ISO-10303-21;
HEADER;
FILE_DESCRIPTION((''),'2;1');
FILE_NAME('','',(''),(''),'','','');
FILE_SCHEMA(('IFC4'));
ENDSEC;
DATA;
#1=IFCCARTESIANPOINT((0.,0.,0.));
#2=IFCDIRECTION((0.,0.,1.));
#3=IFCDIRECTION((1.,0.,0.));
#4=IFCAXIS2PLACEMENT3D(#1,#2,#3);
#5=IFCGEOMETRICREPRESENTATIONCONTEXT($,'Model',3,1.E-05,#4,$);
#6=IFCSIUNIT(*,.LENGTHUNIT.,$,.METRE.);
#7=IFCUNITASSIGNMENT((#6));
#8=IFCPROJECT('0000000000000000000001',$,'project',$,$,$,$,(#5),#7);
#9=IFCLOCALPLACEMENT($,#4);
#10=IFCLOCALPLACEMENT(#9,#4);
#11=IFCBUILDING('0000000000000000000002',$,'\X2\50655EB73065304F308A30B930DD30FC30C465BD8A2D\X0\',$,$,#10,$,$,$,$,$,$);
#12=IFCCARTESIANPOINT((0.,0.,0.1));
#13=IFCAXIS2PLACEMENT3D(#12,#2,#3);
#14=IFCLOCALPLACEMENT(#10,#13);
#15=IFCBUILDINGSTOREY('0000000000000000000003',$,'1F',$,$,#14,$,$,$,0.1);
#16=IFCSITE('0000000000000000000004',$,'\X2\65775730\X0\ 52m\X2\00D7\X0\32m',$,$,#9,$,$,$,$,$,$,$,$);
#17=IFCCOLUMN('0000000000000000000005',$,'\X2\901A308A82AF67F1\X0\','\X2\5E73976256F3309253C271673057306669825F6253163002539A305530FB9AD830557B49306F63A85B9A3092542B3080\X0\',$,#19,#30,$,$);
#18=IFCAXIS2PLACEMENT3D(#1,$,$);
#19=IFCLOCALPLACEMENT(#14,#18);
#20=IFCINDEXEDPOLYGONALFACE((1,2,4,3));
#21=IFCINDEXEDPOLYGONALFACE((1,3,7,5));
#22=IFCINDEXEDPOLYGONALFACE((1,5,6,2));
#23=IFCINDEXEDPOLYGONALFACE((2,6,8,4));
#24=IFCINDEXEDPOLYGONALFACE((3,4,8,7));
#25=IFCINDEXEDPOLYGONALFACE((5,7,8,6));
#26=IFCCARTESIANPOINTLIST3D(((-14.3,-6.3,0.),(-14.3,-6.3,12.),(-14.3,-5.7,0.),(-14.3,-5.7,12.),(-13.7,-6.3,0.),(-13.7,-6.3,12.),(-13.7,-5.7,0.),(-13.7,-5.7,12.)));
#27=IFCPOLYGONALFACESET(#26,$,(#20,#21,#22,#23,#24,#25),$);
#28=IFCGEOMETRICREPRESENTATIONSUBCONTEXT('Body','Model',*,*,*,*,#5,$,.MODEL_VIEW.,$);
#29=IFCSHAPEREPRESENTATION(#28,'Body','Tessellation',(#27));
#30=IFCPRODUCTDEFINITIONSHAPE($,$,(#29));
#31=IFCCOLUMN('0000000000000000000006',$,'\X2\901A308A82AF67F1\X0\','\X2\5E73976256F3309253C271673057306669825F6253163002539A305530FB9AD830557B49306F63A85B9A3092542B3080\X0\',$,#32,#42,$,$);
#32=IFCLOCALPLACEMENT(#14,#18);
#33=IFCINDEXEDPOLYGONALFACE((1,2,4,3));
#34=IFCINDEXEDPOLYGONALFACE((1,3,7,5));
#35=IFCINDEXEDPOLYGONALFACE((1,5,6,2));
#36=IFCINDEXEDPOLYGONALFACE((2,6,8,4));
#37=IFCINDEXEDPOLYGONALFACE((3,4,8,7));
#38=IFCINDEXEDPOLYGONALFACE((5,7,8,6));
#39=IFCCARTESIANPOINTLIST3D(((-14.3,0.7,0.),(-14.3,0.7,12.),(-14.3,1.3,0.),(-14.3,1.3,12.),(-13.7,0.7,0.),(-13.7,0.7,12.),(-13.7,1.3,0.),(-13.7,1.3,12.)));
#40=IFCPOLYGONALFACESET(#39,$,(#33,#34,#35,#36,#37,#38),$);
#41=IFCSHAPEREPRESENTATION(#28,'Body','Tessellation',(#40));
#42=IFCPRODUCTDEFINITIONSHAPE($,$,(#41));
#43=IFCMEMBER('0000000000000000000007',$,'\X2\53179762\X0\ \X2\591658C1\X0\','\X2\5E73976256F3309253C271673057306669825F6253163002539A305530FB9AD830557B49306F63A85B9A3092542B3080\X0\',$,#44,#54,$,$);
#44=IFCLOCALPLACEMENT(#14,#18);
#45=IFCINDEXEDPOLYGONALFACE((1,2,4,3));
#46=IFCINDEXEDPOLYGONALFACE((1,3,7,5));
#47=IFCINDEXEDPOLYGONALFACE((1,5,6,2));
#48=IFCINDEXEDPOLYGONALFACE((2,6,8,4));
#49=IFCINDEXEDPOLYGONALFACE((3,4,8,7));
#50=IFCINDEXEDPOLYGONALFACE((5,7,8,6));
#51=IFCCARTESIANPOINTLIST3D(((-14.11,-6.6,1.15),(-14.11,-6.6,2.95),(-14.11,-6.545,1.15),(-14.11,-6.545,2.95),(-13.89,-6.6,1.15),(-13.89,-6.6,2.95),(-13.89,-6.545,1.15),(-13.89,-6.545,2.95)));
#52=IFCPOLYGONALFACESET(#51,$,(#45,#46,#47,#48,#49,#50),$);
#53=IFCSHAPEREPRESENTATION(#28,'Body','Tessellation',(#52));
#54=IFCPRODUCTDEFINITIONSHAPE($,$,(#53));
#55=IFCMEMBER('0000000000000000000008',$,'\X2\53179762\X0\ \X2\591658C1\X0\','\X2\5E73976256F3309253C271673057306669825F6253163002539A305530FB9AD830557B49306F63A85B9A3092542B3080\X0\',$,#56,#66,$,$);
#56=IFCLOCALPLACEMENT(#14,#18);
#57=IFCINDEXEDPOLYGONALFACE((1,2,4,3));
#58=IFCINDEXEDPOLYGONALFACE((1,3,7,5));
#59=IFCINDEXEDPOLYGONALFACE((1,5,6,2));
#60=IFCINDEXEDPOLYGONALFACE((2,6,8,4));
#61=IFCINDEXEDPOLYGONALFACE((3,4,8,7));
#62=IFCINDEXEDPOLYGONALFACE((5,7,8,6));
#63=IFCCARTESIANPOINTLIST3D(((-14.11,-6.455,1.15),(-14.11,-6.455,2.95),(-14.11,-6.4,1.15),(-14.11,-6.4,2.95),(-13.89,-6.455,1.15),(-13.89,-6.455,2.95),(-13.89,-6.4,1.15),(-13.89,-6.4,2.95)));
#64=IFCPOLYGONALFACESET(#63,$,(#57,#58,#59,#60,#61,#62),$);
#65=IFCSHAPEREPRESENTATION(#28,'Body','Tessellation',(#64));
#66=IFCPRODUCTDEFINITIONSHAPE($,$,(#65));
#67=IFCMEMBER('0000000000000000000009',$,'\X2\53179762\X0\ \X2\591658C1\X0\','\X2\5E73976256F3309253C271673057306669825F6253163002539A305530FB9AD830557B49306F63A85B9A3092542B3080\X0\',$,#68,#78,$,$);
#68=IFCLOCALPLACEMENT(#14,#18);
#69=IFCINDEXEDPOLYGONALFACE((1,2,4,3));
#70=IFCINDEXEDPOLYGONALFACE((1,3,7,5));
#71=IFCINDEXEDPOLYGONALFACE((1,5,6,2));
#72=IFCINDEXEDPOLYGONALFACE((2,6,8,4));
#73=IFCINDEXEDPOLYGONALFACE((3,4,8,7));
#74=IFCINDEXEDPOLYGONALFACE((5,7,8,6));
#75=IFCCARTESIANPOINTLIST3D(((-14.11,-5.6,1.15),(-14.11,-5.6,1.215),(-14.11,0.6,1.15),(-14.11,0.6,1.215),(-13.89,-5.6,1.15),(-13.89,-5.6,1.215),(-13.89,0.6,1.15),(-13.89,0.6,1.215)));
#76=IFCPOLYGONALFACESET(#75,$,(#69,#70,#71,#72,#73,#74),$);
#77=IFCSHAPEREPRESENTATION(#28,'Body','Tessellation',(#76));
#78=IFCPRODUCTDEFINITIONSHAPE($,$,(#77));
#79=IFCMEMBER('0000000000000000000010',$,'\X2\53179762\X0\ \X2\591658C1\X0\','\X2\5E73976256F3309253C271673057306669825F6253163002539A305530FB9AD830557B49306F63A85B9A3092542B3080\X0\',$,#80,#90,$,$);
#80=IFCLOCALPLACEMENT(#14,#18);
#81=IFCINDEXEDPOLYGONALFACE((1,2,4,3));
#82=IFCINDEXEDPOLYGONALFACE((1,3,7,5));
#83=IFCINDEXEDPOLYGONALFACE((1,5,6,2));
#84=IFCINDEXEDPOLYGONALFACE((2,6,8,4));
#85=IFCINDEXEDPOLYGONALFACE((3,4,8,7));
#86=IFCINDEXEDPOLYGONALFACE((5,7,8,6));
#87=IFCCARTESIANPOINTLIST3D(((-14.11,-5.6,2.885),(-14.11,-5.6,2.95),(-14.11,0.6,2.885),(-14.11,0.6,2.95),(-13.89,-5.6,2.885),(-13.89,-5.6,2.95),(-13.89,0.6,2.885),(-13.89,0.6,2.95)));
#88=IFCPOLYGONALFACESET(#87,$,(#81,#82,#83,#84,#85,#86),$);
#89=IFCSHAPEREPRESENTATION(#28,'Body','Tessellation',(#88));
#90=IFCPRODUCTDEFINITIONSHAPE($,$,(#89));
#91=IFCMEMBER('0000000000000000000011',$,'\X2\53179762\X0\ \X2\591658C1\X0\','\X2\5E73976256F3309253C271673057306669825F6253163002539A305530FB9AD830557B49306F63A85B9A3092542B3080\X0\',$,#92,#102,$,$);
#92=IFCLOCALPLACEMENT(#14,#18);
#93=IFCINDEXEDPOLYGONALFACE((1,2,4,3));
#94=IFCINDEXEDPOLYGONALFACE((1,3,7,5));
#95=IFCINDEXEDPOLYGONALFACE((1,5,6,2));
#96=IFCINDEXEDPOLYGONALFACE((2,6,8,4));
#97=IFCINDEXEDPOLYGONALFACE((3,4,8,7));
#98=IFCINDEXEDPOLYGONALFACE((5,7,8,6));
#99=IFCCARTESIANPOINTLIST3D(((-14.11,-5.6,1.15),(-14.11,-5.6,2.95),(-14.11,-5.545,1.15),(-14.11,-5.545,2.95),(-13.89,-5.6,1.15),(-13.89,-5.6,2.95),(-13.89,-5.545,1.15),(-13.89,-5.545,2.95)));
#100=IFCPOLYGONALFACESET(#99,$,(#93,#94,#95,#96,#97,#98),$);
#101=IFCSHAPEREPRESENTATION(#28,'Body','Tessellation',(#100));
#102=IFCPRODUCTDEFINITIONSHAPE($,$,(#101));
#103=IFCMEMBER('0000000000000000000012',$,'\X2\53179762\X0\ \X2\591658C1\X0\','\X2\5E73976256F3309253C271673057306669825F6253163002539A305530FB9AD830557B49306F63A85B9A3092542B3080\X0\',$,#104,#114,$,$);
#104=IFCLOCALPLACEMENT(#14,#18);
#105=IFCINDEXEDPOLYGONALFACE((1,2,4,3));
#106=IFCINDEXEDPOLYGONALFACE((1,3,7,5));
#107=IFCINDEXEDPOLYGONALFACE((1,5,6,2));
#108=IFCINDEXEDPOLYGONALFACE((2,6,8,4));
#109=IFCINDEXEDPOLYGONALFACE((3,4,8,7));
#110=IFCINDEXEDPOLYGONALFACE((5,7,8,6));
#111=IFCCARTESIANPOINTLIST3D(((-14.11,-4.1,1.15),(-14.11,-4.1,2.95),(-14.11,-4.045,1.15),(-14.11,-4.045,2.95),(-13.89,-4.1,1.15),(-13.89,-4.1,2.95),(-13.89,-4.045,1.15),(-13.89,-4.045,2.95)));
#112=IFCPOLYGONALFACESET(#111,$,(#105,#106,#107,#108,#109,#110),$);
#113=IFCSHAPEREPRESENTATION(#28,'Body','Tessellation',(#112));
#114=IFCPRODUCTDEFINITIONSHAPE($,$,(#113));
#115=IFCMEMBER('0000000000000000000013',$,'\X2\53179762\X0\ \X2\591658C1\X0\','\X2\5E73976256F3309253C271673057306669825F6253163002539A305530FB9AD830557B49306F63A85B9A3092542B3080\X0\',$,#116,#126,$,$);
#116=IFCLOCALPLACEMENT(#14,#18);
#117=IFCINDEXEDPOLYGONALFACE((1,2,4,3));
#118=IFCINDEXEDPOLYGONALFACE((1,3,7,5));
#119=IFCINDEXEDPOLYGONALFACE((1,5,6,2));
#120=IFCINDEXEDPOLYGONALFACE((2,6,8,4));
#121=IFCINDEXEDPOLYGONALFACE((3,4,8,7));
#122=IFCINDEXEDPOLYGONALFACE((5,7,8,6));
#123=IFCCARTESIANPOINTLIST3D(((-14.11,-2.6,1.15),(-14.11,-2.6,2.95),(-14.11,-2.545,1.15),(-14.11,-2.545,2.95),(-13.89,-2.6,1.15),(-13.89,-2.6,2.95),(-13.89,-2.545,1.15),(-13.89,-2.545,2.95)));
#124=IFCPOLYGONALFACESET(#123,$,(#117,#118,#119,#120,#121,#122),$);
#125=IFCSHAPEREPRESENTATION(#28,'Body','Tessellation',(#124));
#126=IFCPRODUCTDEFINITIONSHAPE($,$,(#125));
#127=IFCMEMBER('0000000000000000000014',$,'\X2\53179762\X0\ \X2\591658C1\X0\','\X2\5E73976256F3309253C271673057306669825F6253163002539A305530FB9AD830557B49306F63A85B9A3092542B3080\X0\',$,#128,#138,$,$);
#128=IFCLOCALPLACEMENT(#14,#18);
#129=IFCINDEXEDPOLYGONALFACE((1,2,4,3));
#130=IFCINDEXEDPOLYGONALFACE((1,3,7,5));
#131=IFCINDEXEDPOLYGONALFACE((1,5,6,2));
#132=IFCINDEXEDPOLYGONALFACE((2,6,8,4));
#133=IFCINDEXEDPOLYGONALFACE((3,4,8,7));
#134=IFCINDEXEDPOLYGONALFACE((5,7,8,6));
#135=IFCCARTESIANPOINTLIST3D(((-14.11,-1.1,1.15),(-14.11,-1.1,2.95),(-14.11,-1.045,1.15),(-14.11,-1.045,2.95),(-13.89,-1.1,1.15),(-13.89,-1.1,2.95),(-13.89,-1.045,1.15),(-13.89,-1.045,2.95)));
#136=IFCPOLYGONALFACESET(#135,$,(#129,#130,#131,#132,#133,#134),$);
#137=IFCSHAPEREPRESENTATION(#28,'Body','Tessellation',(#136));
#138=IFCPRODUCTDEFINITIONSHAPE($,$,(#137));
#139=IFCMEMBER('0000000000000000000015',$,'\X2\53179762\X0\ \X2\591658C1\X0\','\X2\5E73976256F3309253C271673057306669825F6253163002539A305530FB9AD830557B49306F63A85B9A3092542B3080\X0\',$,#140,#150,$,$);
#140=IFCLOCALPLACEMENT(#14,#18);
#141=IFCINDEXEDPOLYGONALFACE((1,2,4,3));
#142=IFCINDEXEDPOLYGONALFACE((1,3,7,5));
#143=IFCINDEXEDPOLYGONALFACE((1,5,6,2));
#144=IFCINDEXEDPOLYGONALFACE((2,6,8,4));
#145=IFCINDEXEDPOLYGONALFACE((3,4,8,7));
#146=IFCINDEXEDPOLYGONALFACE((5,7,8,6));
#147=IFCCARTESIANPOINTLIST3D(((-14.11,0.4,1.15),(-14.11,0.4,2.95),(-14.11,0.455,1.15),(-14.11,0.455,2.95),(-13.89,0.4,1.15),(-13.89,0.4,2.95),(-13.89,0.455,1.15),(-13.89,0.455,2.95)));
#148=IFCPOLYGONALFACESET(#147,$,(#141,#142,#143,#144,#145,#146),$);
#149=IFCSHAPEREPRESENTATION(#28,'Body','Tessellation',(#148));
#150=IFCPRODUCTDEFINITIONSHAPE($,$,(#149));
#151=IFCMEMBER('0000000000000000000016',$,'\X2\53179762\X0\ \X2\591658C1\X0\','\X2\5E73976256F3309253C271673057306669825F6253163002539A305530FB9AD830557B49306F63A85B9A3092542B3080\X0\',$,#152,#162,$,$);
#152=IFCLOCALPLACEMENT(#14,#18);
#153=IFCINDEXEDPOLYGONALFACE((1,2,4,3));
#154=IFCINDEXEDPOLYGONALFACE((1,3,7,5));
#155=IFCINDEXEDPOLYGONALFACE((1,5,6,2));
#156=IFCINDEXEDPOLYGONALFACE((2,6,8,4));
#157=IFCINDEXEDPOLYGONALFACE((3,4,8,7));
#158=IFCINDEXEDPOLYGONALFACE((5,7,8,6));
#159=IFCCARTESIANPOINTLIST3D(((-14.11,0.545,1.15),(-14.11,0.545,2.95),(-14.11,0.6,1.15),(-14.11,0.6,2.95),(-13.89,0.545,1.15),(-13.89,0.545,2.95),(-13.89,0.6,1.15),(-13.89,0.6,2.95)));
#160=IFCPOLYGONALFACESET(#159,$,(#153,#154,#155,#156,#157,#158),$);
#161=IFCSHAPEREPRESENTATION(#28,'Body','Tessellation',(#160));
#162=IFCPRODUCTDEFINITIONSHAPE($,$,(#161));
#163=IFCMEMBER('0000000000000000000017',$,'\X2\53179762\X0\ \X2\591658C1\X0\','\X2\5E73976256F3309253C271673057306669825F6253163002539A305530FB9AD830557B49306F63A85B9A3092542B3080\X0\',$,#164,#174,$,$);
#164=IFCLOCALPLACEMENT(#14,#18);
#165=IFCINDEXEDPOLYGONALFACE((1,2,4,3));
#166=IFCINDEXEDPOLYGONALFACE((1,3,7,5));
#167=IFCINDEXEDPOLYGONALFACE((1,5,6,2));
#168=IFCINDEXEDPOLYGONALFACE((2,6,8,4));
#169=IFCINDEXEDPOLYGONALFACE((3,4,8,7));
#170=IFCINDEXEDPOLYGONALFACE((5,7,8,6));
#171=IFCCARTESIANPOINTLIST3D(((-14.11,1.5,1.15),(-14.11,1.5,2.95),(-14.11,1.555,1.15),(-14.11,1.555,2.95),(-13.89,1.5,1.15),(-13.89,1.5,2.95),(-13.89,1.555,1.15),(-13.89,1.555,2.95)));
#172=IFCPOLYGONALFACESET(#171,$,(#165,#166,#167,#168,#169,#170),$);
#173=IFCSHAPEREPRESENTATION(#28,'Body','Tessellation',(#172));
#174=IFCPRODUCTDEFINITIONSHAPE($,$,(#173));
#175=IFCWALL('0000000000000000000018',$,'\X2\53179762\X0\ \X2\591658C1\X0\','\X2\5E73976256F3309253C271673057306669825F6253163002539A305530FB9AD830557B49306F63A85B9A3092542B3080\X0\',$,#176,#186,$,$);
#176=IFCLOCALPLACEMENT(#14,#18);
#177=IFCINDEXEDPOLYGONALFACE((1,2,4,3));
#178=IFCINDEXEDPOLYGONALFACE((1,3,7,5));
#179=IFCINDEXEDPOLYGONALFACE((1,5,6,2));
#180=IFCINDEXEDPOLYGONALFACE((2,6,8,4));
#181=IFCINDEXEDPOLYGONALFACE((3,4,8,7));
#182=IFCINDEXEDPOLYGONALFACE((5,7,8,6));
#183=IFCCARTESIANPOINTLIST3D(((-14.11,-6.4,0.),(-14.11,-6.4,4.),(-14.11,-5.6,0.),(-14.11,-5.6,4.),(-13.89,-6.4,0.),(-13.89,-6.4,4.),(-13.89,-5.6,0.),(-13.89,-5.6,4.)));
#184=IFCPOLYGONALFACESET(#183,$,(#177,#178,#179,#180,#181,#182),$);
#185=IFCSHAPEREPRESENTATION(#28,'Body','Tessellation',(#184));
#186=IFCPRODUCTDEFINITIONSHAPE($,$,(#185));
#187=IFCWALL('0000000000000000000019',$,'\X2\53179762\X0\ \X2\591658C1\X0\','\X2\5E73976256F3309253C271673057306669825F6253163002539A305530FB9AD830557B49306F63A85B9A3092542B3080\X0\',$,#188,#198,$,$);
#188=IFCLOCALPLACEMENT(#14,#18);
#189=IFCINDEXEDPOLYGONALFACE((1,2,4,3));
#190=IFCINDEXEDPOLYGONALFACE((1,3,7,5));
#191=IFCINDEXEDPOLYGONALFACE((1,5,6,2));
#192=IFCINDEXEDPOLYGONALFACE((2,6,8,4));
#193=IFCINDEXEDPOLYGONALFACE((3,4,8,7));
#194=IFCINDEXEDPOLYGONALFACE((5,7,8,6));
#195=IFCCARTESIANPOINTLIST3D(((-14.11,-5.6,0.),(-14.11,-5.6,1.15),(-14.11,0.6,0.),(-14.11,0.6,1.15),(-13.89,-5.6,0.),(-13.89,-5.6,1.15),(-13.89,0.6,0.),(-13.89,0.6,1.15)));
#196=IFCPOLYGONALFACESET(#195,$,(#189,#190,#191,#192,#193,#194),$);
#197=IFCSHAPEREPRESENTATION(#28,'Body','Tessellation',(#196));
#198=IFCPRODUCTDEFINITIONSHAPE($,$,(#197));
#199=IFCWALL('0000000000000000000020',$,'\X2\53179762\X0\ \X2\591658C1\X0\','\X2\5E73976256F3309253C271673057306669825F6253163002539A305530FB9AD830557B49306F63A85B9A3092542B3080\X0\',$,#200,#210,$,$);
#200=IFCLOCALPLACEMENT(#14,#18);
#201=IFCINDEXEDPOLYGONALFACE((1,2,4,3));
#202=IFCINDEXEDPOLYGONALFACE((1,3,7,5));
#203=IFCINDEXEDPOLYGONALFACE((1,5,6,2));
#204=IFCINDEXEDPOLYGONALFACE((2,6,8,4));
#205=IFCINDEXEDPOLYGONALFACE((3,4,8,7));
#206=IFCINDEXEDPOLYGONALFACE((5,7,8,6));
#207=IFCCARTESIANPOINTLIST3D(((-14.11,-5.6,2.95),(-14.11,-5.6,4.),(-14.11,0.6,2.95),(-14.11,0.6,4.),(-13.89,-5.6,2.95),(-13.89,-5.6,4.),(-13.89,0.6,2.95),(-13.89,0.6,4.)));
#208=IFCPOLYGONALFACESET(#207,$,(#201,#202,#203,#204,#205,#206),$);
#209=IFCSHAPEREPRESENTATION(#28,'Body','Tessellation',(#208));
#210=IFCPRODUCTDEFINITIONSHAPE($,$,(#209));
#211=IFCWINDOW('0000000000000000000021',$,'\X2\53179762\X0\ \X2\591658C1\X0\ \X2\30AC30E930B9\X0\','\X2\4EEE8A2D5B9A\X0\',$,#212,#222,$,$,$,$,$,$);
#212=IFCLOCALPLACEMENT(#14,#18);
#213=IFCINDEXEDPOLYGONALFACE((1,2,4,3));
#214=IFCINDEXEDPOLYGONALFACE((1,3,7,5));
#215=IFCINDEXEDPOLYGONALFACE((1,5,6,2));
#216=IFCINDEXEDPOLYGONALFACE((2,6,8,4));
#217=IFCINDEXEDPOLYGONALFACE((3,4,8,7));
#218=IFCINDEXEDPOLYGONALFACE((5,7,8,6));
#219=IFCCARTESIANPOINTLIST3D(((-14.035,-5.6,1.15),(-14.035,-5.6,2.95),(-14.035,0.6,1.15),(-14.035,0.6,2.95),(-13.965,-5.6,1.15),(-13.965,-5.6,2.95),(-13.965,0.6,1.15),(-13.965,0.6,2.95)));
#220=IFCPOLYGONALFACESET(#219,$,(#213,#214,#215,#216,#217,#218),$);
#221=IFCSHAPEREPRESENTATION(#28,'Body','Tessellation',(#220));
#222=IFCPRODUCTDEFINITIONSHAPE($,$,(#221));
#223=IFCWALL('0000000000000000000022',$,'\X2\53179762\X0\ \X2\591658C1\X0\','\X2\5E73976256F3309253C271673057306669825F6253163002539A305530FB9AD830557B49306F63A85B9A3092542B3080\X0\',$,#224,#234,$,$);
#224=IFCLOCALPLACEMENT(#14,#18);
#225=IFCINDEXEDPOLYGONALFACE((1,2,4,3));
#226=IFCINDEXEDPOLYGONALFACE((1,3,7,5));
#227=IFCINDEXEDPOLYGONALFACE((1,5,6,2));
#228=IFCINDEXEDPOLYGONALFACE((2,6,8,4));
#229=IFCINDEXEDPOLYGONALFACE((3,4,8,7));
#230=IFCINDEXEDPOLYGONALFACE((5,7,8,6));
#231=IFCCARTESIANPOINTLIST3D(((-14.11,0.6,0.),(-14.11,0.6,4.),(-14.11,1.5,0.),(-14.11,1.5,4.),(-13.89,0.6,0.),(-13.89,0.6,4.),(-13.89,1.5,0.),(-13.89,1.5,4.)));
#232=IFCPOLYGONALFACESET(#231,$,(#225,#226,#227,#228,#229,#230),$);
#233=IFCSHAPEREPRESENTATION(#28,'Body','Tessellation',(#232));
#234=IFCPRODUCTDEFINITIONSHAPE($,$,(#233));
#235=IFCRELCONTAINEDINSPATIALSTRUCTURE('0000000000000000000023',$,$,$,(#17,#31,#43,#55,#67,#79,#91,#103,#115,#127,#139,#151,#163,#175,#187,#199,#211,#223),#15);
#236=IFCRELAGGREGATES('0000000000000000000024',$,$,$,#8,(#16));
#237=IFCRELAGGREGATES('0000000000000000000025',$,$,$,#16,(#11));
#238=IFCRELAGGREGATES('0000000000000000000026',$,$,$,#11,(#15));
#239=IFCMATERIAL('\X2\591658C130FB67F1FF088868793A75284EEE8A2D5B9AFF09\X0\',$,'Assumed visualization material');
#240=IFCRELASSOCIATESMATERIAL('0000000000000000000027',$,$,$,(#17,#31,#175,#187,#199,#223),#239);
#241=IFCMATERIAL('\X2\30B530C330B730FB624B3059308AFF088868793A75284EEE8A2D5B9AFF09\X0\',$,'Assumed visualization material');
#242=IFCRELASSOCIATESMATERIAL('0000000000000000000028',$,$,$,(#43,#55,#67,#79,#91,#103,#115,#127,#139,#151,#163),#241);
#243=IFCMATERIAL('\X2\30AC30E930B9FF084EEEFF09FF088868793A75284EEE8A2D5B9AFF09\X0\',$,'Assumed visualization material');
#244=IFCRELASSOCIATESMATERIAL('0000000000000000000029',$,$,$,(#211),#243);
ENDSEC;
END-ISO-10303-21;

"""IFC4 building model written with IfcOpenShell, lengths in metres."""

from ifc_helpers import new_model, si_unit, frame, origin_with_axes, place, context, subcontext, project, spatial, rectangle, extrude, material, element, save


model = new_model("IFC4")

# Units and contexts
model_context = context("Model", 3, precision=1e-05, world=origin_with_axes())
body_context = subcontext(model_context, "Body", "Model", "MODEL_VIEW")
ifc_project = project(units=[si_unit("LENGTHUNIT", "METRE")], contexts=[model_context])

# Site, building, storey
site_placement = place(None, origin_with_axes())
site = spatial("IfcSite", under=ifc_project, at=site_placement, Name="敷地 52m×32m")
building_placement = place(site_placement, origin_with_axes())
building = spatial("IfcBuilding", under=site, at=building_placement, Name="健康づくりスポーツ施設")
storey_placement = place(building_placement, frame((0.0, 0.0, 0.1), z_axis=(0.0, 0.0, 1.0), x_axis=(1.0, 0.0, 0.0)))
storey = spatial("IfcBuildingStorey", under=building, at=storey_placement, Name="1F", Elevation=0.1)

# Columns
ifc_material_1 = material(Name="外壁・柱（表示用仮設定）", Category="Assumed visualization material")
for number, where, z_axis, x_axis, name in (
    (1, (-14.0, -6.0, 0.0), (0.0, 0.0, 1.0), (1.0, 0.0, 0.0), "通り芯柱"),
    (2, (-14.0, 1.0, 0.0), (0.0, 0.0, 1.0), (1.0, 0.0, 0.0), "通り芯柱"),
):
    element("IfcColumn", number, at=place(storey_placement, frame(where, z_axis=z_axis, x_axis=x_axis)), inside=storey, material=ifc_material_1, Name=name, Description="平面図を参照して概形化。厚さ・高さ等は推定を含む", context=body_context, shape_type="SweptSolid", body=[
        extrude(rectangle(XDim=0.6, YDim=0.6), origin_with_axes(), (0.0, 0.0, 1.0), 12.0),
    ])

# Members
ifc_material_2 = material(Name="サッシ・手すり（表示用仮設定）", Category="Assumed visualization material")
for number, where, z_axis, x_axis, name in (
    (3, (-14.0, -6.5725, 1.15), (0.0, 0.0, 1.0), (1.0, 0.0, 0.0), "北面 外壁"),
    (4, (-14.0, -6.4275, 1.15), (0.0, 0.0, 1.0), (1.0, 0.0, 0.0), "北面 外壁"),
):
    element("IfcMember", number, at=place(storey_placement, frame(where, z_axis=z_axis, x_axis=x_axis)), inside=storey, material=ifc_material_2, Name=name, Description="平面図を参照して概形化。厚さ・高さ等は推定を含む", context=body_context, shape_type="SweptSolid", body=[
        extrude(rectangle(XDim=0.22, YDim=0.055), origin_with_axes(), (0.0, 0.0, 1.0), 1.8),
    ])
for number, where, z_axis, x_axis, name in (
    (5, (-14.0, -2.5, 1.15), (0.0, 0.0, 1.0), (1.0, 0.0, 0.0), "北面 外壁"),
    (6, (-14.0, -2.5, 2.885), (0.0, 0.0, 1.0), (1.0, 0.0, 0.0), "北面 外壁"),
):
    element("IfcMember", number, at=place(storey_placement, frame(where, z_axis=z_axis, x_axis=x_axis)), inside=storey, material=ifc_material_2, Name=name, Description="平面図を参照して概形化。厚さ・高さ等は推定を含む", context=body_context, shape_type="SweptSolid", body=[
        extrude(rectangle(XDim=0.22, YDim=6.2), origin_with_axes(), (0.0, 0.0, 1.0), 0.065),
    ])
for number, where, z_axis, x_axis, name in (
    (7, (-14.0, -5.5725, 1.15), (0.0, 0.0, 1.0), (1.0, 0.0, 0.0), "北面 外壁"),
    (8, (-14.0, -4.0725, 1.15), (0.0, 0.0, 1.0), (1.0, 0.0, 0.0), "北面 外壁"),
    (9, (-14.0, -2.5725, 1.15), (0.0, 0.0, 1.0), (1.0, 0.0, 0.0), "北面 外壁"),
    (10, (-14.0, -1.0725, 1.15), (0.0, 0.0, 1.0), (1.0, 0.0, 0.0), "北面 外壁"),
    (11, (-14.0, 0.4275, 1.15), (0.0, 0.0, 1.0), (1.0, 0.0, 0.0), "北面 外壁"),
    (12, (-14.0, 0.5725, 1.15), (0.0, 0.0, 1.0), (1.0, 0.0, 0.0), "北面 外壁"),
    (13, (-14.0, 1.5275, 1.15), (0.0, 0.0, 1.0), (1.0, 0.0, 0.0), "北面 外壁"),
):
    element("IfcMember", number, at=place(storey_placement, frame(where, z_axis=z_axis, x_axis=x_axis)), inside=storey, material=ifc_material_2, Name=name, Description="平面図を参照して概形化。厚さ・高さ等は推定を含む", context=body_context, shape_type="SweptSolid", body=[
        extrude(rectangle(XDim=0.22, YDim=0.055), origin_with_axes(), (0.0, 0.0, 1.0), 1.8),
    ])

# Walls
wall_1_placement = place(storey_placement, frame((-14.0, -6.0, 0.0), z_axis=(0.0, 0.0, 1.0), x_axis=(1.0, 0.0, 0.0)))
element("IfcWall", 14, at=wall_1_placement, inside=storey, material=ifc_material_1, Name="北面 外壁", Description="平面図を参照して概形化。厚さ・高さ等は推定を含む", context=body_context, shape_type="SweptSolid", body=[
    extrude(rectangle(XDim=0.22, YDim=0.8), origin_with_axes(), (0.0, 0.0, 1.0), 4.0),
])
wall_2_placement = place(storey_placement, frame((-14.0, -2.5, 0.0), z_axis=(0.0, 0.0, 1.0), x_axis=(1.0, 0.0, 0.0)))
element("IfcWall", 15, at=wall_2_placement, inside=storey, material=ifc_material_1, Name="北面 外壁", Description="平面図を参照して概形化。厚さ・高さ等は推定を含む", context=body_context, shape_type="SweptSolid", body=[
    extrude(rectangle(XDim=0.22, YDim=6.2), origin_with_axes(), (0.0, 0.0, 1.0), 1.15),
])
wall_3_placement = place(storey_placement, frame((-14.0, -2.5, 2.95), z_axis=(0.0, 0.0, 1.0), x_axis=(1.0, 0.0, 0.0)))
element("IfcWall", 16, at=wall_3_placement, inside=storey, material=ifc_material_1, Name="北面 外壁", Description="平面図を参照して概形化。厚さ・高さ等は推定を含む", context=body_context, shape_type="SweptSolid", body=[
    extrude(rectangle(XDim=0.22, YDim=6.2), origin_with_axes(), (0.0, 0.0, 1.0), 1.05),
])

# Window
ifc_material_3 = material(Name="ガラス（仮）（表示用仮設定）", Category="Assumed visualization material")
window_placement = place(storey_placement, frame((-14.0, -2.5, 1.15), z_axis=(0.0, 0.0, 1.0), x_axis=(1.0, 0.0, 0.0)))
element("IfcWindow", 17, at=window_placement, inside=storey, material=ifc_material_3, Name="北面 外壁 ガラス", Description="仮設定", context=body_context, shape_type="SweptSolid", body=[
    extrude(rectangle(XDim=0.07, YDim=6.2), origin_with_axes(), (0.0, 0.0, 1.0), 1.8),
])

# Wall
wall_4_placement = place(storey_placement, frame((-14.0, 1.05, 0.0), z_axis=(0.0, 0.0, 1.0), x_axis=(1.0, 0.0, 0.0)))
element("IfcWall", 18, at=wall_4_placement, inside=storey, material=ifc_material_1, Name="北面 外壁", Description="平面図を参照して概形化。厚さ・高さ等は推定を含む", context=body_context, shape_type="SweptSolid", body=[
    extrude(rectangle(XDim=0.22, YDim=0.9), origin_with_axes(), (0.0, 0.0, 1.0), 4.0),
])

save(model, "model.ifc")
